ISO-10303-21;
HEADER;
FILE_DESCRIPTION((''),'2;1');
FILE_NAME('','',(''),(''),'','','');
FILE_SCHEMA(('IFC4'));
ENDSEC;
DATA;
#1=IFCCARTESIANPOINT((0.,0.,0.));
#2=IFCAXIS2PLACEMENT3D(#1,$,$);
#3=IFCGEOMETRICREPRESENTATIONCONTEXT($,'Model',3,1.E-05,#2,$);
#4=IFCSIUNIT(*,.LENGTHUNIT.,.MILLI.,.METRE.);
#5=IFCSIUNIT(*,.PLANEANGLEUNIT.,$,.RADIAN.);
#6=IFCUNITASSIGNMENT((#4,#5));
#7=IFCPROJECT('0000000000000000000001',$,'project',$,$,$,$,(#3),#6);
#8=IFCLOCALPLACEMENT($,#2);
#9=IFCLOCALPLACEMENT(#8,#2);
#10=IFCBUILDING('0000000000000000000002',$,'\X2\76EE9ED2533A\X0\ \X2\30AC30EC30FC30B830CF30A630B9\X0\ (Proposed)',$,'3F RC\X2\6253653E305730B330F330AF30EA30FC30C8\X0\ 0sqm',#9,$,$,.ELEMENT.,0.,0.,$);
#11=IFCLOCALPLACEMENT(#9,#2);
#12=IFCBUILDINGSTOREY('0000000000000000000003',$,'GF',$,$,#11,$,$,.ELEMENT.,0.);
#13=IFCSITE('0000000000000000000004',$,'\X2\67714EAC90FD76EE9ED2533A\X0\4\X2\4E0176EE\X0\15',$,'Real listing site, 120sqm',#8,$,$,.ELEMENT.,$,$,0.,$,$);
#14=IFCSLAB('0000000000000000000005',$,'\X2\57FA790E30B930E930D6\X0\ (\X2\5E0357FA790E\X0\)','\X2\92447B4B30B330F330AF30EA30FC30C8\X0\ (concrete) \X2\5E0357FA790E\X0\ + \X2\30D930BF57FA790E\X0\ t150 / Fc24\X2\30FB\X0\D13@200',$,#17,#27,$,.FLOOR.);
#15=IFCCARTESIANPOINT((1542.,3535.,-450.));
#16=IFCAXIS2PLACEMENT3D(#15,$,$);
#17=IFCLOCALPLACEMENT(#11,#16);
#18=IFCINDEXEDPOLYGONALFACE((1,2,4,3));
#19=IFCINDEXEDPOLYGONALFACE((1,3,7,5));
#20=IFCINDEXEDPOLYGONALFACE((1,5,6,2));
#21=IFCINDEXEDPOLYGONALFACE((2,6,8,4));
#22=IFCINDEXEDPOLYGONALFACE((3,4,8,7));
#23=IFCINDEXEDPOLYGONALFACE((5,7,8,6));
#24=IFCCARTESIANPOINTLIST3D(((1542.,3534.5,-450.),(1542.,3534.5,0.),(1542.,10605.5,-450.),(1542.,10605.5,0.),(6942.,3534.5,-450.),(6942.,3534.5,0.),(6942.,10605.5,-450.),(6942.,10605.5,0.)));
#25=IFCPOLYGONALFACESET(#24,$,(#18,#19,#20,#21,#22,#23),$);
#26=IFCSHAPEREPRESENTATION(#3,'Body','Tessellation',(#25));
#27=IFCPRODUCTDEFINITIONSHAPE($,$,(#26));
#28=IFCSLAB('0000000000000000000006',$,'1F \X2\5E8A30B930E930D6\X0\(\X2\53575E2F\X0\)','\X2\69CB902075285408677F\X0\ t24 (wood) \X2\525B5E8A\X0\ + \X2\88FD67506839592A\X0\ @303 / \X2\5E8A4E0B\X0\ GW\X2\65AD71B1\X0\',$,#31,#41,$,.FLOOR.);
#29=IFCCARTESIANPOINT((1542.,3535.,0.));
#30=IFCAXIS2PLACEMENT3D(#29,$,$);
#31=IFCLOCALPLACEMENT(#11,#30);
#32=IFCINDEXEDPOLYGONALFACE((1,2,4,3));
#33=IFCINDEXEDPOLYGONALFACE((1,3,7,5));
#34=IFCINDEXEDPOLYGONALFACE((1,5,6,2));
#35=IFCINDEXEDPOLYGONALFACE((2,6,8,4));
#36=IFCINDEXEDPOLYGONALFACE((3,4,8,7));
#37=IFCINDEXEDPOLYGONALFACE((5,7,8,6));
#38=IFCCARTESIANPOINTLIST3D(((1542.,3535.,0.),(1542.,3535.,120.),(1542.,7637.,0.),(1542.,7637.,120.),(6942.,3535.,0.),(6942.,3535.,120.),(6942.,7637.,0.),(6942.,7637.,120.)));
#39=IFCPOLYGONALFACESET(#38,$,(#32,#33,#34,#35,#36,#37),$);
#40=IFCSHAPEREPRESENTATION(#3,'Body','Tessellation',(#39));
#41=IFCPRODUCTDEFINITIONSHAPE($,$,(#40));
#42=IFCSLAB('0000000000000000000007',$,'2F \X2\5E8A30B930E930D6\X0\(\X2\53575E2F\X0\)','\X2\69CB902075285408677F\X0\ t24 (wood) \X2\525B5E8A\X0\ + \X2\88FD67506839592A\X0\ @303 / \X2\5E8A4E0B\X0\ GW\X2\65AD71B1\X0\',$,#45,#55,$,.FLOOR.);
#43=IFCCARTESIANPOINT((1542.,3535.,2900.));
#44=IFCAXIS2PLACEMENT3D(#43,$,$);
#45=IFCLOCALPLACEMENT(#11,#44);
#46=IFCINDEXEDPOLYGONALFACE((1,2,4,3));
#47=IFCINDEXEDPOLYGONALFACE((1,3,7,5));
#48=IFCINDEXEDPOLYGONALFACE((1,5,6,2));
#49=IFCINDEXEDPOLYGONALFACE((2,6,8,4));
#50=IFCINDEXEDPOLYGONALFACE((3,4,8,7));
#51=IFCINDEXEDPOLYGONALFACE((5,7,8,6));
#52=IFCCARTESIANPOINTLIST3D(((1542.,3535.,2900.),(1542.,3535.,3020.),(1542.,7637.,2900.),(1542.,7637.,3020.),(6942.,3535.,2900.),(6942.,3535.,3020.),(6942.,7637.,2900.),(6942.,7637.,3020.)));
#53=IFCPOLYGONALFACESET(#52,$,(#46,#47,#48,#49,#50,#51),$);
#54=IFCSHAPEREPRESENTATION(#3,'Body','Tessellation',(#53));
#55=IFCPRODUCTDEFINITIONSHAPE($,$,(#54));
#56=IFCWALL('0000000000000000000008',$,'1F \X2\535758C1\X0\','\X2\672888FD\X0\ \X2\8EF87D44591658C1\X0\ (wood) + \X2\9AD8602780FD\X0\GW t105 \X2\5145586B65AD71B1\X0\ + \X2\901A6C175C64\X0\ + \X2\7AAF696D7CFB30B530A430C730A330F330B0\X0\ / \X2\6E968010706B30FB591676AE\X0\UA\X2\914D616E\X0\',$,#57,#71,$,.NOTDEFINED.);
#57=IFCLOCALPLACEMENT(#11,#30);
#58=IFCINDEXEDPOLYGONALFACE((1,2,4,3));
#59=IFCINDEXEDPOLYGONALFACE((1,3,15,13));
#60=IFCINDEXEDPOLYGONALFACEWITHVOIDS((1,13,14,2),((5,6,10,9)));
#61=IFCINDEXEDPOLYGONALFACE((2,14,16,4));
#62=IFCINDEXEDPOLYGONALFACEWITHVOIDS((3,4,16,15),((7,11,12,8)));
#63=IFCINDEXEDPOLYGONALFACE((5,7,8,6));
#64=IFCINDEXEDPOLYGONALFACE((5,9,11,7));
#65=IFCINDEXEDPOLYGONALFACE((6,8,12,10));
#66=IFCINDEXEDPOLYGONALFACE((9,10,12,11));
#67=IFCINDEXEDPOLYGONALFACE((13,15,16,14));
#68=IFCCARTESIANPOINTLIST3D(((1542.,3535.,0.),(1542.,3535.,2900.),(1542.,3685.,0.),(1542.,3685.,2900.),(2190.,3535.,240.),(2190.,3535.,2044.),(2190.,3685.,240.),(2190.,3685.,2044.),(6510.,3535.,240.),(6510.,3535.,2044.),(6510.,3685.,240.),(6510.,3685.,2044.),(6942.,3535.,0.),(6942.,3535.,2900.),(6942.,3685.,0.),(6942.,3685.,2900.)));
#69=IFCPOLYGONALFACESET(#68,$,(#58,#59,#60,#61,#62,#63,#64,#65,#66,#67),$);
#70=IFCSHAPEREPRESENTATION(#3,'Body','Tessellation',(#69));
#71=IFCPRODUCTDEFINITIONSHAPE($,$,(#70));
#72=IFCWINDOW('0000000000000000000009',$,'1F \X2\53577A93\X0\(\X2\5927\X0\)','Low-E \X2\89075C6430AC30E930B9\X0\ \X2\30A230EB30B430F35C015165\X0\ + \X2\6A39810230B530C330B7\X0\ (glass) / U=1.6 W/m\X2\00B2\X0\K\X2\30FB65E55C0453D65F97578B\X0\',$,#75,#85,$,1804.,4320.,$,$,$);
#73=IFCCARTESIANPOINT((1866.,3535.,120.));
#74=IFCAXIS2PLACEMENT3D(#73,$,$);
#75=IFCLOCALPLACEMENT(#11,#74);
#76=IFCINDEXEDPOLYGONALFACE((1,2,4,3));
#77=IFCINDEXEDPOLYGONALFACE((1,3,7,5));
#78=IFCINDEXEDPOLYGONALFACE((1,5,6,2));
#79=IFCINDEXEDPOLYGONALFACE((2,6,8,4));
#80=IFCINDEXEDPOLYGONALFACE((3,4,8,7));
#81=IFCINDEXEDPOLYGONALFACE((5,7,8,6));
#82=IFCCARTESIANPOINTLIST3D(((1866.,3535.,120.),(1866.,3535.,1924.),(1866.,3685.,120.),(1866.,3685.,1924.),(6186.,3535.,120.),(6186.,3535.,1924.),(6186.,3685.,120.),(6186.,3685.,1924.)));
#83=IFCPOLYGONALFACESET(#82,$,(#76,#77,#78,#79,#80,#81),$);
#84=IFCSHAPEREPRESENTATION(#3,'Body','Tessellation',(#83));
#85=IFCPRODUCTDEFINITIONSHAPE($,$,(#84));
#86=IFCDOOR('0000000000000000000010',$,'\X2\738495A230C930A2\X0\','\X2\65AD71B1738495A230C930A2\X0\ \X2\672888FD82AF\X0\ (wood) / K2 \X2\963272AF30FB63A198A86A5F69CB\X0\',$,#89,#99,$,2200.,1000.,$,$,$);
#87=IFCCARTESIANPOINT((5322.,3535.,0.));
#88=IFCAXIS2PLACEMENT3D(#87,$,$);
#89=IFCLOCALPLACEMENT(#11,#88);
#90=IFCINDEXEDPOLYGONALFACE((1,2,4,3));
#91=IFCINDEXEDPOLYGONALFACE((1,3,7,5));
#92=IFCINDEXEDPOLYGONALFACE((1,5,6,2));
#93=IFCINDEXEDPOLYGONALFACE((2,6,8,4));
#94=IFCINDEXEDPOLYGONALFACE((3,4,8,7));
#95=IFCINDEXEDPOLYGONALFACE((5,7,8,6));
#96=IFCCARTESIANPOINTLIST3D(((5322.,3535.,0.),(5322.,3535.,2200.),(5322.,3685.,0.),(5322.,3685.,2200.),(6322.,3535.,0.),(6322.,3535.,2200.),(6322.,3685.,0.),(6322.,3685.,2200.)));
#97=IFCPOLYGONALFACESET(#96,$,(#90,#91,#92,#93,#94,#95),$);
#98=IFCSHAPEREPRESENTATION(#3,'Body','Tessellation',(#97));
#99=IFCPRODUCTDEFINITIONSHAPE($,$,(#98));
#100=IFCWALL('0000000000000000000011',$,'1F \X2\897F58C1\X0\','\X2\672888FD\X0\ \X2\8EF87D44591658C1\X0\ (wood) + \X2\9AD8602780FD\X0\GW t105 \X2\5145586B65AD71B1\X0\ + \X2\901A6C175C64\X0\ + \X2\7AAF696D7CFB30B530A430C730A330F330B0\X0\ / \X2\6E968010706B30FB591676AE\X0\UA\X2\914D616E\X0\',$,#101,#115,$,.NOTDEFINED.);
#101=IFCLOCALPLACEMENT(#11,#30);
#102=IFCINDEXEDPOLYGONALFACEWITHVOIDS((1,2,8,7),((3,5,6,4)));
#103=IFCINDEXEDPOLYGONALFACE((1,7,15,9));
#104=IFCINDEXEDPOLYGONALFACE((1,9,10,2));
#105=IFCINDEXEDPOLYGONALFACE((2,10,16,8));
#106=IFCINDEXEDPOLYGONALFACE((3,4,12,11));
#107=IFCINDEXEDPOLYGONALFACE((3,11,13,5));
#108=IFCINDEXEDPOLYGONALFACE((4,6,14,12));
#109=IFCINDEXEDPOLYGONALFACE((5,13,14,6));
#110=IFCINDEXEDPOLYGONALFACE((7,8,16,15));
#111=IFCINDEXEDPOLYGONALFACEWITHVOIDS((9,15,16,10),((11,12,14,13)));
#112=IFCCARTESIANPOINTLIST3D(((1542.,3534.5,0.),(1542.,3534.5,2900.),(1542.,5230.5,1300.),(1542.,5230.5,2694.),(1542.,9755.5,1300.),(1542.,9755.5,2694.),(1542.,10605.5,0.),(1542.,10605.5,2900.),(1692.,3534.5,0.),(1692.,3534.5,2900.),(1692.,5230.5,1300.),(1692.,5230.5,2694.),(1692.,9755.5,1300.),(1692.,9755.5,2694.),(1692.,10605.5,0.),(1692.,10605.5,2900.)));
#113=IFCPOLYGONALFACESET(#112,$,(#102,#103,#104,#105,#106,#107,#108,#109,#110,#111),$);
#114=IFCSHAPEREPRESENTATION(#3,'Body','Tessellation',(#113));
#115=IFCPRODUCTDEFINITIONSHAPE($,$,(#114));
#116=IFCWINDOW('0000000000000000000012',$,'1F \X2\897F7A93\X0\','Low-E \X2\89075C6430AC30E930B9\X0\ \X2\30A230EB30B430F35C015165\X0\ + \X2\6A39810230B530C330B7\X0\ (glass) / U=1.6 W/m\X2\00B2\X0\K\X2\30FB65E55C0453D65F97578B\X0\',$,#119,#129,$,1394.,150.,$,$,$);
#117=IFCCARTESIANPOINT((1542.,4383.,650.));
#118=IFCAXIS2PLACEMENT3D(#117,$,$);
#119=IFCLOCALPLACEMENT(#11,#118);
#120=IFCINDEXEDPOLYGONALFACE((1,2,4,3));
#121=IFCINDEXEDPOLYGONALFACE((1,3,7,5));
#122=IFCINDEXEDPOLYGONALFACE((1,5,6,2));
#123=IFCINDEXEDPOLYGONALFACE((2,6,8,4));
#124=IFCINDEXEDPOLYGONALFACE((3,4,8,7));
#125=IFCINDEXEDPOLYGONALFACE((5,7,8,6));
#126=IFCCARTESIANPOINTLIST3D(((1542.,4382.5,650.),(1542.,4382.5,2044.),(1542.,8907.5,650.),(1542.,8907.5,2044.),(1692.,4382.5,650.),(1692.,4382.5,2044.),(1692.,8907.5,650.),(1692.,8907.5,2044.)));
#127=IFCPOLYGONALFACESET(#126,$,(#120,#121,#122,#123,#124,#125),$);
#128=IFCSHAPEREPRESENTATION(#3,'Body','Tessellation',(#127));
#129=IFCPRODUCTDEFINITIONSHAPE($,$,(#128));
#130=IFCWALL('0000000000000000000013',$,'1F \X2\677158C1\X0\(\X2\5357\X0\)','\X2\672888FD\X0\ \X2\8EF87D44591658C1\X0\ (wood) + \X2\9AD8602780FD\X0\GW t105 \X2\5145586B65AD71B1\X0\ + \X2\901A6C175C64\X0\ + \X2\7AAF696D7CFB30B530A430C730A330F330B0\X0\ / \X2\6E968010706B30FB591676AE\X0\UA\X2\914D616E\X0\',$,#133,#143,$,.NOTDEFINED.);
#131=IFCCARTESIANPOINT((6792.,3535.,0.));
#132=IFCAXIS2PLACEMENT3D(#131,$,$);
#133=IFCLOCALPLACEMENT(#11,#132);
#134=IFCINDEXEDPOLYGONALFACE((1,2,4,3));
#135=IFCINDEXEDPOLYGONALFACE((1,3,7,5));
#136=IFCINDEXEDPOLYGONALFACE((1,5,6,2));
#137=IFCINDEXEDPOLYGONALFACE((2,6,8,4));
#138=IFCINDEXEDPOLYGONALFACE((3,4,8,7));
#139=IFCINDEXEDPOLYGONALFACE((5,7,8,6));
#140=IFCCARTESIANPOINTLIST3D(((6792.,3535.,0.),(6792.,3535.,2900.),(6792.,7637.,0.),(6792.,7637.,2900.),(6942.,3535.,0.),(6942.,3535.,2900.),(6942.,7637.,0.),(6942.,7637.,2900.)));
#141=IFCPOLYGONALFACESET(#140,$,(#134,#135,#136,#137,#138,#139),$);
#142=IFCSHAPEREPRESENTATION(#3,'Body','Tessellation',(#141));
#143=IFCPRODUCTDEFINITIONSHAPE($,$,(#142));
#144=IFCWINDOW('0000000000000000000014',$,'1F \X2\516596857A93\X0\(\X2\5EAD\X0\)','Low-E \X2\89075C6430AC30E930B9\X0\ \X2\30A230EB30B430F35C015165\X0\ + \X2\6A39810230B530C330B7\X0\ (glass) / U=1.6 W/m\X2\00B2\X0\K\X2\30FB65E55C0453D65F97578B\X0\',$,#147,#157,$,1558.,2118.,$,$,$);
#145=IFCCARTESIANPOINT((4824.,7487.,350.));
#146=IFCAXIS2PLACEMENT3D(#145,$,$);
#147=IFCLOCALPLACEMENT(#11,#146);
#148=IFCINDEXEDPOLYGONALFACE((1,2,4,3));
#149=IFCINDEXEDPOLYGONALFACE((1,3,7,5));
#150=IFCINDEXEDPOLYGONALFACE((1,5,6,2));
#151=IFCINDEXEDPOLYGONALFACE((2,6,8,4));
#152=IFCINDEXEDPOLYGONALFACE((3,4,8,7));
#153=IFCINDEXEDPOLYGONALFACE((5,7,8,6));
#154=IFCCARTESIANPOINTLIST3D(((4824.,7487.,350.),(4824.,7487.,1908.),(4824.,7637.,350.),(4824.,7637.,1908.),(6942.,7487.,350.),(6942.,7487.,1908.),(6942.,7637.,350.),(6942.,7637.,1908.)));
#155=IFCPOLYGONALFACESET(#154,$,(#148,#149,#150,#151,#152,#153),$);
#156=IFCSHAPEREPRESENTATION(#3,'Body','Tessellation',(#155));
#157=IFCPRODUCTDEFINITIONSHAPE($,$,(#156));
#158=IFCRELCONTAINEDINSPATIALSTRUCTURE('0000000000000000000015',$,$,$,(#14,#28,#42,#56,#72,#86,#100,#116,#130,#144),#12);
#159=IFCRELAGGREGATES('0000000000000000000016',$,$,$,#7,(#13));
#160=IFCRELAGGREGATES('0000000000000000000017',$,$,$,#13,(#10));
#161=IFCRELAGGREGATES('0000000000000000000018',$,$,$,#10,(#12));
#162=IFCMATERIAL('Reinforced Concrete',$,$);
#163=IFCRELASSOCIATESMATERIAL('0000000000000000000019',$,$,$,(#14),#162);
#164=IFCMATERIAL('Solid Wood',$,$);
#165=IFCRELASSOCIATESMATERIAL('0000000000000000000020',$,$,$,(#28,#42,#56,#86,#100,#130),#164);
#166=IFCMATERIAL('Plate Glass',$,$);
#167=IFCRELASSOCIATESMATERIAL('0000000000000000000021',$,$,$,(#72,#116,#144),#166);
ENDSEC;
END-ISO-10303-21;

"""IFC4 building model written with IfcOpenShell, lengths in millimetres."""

from ifc_helpers import new_model, si_unit, frame, frame_2d, origin, place, context, project, spatial, rectangle, extrude, material, element, fill, save


model = new_model("IFC4")

# Units and contexts
model_context = context("Model", 3, precision=1e-05, world=origin())
ifc_project = project(units=[si_unit("LENGTHUNIT", "METRE", prefix="MILLI"), si_unit("PLANEANGLEUNIT", "RADIAN")], contexts=[model_context])

# Site, building, storey
site_placement = place(None, origin())
site = spatial("IfcSite", under=ifc_project, at=site_placement, Name="東京都目黒区4丁目15", ObjectType="Real listing site, 120sqm", CompositionType="ELEMENT", RefElevation=0.0)
building_placement = place(site_placement, origin())
building = spatial("IfcBuilding", under=site, at=building_placement, Name="目黒区 ガレージハウス (Proposed)", ObjectType="3F RC打放しコンクリート 0sqm", CompositionType="ELEMENT", ElevationOfRefHeight=0.0, ElevationOfTerrain=0.0)
storey_placement = place(building_placement, origin())
storey = spatial("IfcBuildingStorey", under=building, at=storey_placement, Name="GF", CompositionType="ELEMENT", Elevation=0.0)

# Slabs
ifc_material_1 = material(Name="Reinforced Concrete")
slab_1_placement = place(storey_placement, frame((1542.0, 3535.0, -450.0)))
element("IfcSlab", 1, at=slab_1_placement, inside=storey, material=ifc_material_1, Name="基礎スラブ (布基礎)", Description="鉄筋コンクリート (concrete) 布基礎 + ベタ基礎 t150 / Fc24・D13@200", PredefinedType="FLOOR", context=model_context, shape_type="SweptSolid", body=[
    extrude(rectangle(XDim=5400.0, YDim=7071.0, at=frame_2d((2700.0, 3535.0))), frame((1542.0, 3535.0, -450.0)), (0.0, 0.0, 1.0), 450.0),
])
ifc_material_2 = material(Name="Solid Wood")
slab_2_placement = place(storey_placement, frame((1542.0, 3535.0, 0.0)))
element("IfcSlab", 2, at=slab_2_placement, inside=storey, material=ifc_material_2, Name="1F 床スラブ(南帯)", Description="構造用合板 t24 (wood) 剛床 + 製材根太 @303 / 床下 GW断熱", PredefinedType="FLOOR", context=model_context, shape_type="SweptSolid", body=[
    extrude(rectangle(XDim=5400.0, YDim=4102.0, at=frame_2d((2700.0, 2051.0))), frame((1542.0, 3535.0, 0.0)), (0.0, 0.0, 1.0), 120.0),
])
slab_3_placement = place(storey_placement, frame((1542.0, 3535.0, 2900.0)))
element("IfcSlab", 3, at=slab_3_placement, inside=storey, material=ifc_material_2, Name="2F 床スラブ(南帯)", Description="構造用合板 t24 (wood) 剛床 + 製材根太 @303 / 床下 GW断熱", PredefinedType="FLOOR", context=model_context, shape_type="SweptSolid", body=[
    extrude(rectangle(XDim=5400.0, YDim=4102.0, at=frame_2d((2700.0, 2051.0))), frame((1542.0, 3535.0, 2900.0)), (0.0, 0.0, 1.0), 120.0),
])

# Wall, openings, window, door
wall_1_placement = place(storey_placement, frame((1542.0, 3535.0, 0.0)))
wall_1 = element("IfcWall", 4, at=wall_1_placement, inside=storey, material=ifc_material_2, Name="1F 南壁", Description="木製 軸組外壁 (wood) + 高性能GW t105 充填断熱 + 通気層 + 窯業系サイディング / 準耐火・外皮UA配慮", PredefinedType="NOTDEFINED", context=model_context, shape_type="SweptSolid", body=[
    extrude(rectangle(XDim=5400.0, YDim=150.0, at=frame_2d((2700.0, 75.0))), frame((1542.0, 3535.0, 0.0)), (0.0, 0.0, 1.0), 2900.0),
])
opening_1_placement = place(storey_placement, frame((1866.0, 3535.0, 120.0)))
opening_1 = element("IfcOpeningElement", 5, at=opening_1_placement, cuts=wall_1, PredefinedType="NOTDEFINED", context=model_context, shape_type="SweptSolid", body=[
    extrude(rectangle(XDim=4320.0, YDim=150.0, at=frame_2d((2160.0, 75.0))), frame((1866.0, 3535.0, 120.0)), (0.0, 0.0, 1.0), 1804.0),
])
opening_2_placement = place(storey_placement, frame((5322.0, 3535.0, 0.0)))
opening_2 = element("IfcOpeningElement", 6, at=opening_2_placement, cuts=wall_1, PredefinedType="NOTDEFINED", context=model_context, shape_type="SweptSolid", body=[
    extrude(rectangle(XDim=1000.0, YDim=150.0, at=frame_2d((500.0, 75.0))), frame((5322.0, 3535.0, 0.0)), (0.0, 0.0, 1.0), 2200.0),
])
ifc_material_3 = material(Name="Plate Glass")
window_1_placement = place(storey_placement, frame((1866.0, 3535.0, 120.0)))
window_1 = element("IfcWindow", 7, at=window_1_placement, inside=storey, material=ifc_material_3, Name="1F 南窓(大)", Description="Low-E 複層ガラス アルゴン封入 + 樹脂サッシ (glass) / U=1.6 W/m²K・日射取得型", OverallHeight=1804.0, OverallWidth=4320.0, context=model_context, shape_type="SweptSolid", body=[
    extrude(rectangle(XDim=4320.0, YDim=150.0, at=frame_2d((2160.0, 75.0))), frame((1866.0, 3535.0, 120.0)), (0.0, 0.0, 1.0), 1804.0),
])
fill(opening_1, window_1)
door_1_placement = place(storey_placement, frame((5322.0, 3535.0, 0.0)))
door_1 = element("IfcDoor", 8, at=door_1_placement, inside=storey, material=ifc_material_2, Name="玄関ドア", Description="断熱玄関ドア 木製芯 (wood) / K2 防犯・採風機構", OverallHeight=2200.0, OverallWidth=1000.0, context=model_context, shape_type="SweptSolid", body=[
    extrude(rectangle(XDim=1000.0, YDim=150.0, at=frame_2d((500.0, 75.0))), frame((5322.0, 3535.0, 0.0)), (0.0, 0.0, 1.0), 2200.0),
])
fill(opening_2, door_1)

# Walls, openings, windows
wall_2_placement = place(storey_placement, frame((1542.0, 3535.0, 0.0)))
wall_2 = element("IfcWall", 9, at=wall_2_placement, inside=storey, material=ifc_material_2, Name="1F 西壁", Description="木製 軸組外壁 (wood) + 高性能GW t105 充填断熱 + 通気層 + 窯業系サイディング / 準耐火・外皮UA配慮", PredefinedType="NOTDEFINED", context=model_context, shape_type="SweptSolid", body=[
    extrude(rectangle(XDim=150.0, YDim=7071.0, at=frame_2d((75.0, 3535.0))), frame((1542.0, 3535.0, 0.0)), (0.0, 0.0, 1.0), 2900.0),
])
opening_3_placement = place(storey_placement, frame((1542.0, 4383.0, 650.0)))
opening_3 = element("IfcOpeningElement", 10, at=opening_3_placement, cuts=wall_2, PredefinedType="NOTDEFINED", context=model_context, shape_type="SweptSolid", body=[
    extrude(rectangle(XDim=150.0, YDim=4525.0, at=frame_2d((75.0, 2262.0))), frame((1542.0, 4383.0, 650.0)), (0.0, 0.0, 1.0), 1394.0),
])
window_2_placement = place(storey_placement, frame((1542.0, 4383.0, 650.0)))
window_2 = element("IfcWindow", 11, at=window_2_placement, inside=storey, material=ifc_material_3, Name="1F 西窓", Description="Low-E 複層ガラス アルゴン封入 + 樹脂サッシ (glass) / U=1.6 W/m²K・日射取得型", OverallHeight=1394.0, OverallWidth=150.0, context=model_context, shape_type="SweptSolid", body=[
    extrude(rectangle(XDim=150.0, YDim=4525.0, at=frame_2d((75.0, 2262.0))), frame((1542.0, 4383.0, 650.0)), (0.0, 0.0, 1.0), 1394.0),
])
fill(opening_3, window_2)
wall_3_placement = place(storey_placement, frame((6792.0, 3535.0, 0.0)))
wall_3 = element("IfcWall", 12, at=wall_3_placement, inside=storey, material=ifc_material_2, Name="1F 東壁(南)", Description="木製 軸組外壁 (wood) + 高性能GW t105 充填断熱 + 通気層 + 窯業系サイディング / 準耐火・外皮UA配慮", PredefinedType="NOTDEFINED", context=model_context, shape_type="SweptSolid", body=[
    extrude(rectangle(XDim=150.0, YDim=4102.0, at=frame_2d((75.0, 2051.0))), frame((6792.0, 3535.0, 0.0)), (0.0, 0.0, 1.0), 2900.0),
])
opening_4_placement = place(storey_placement, frame((4824.0, 7487.0, 350.0)))
opening_4 = element("IfcOpeningElement", 13, at=opening_4_placement, cuts=wall_3, PredefinedType="NOTDEFINED", context=model_context, shape_type="SweptSolid", body=[
    extrude(rectangle(XDim=2118.0, YDim=150.0, at=frame_2d((1059.0, 75.0))), frame((4824.0, 7487.0, 350.0)), (0.0, 0.0, 1.0), 1558.0),
])
window_3_placement = place(storey_placement, frame((4824.0, 7487.0, 350.0)))
window_3 = element("IfcWindow", 14, at=window_3_placement, inside=storey, material=ifc_material_3, Name="1F 入隅窓(庭)", Description="Low-E 複層ガラス アルゴン封入 + 樹脂サッシ (glass) / U=1.6 W/m²K・日射取得型", OverallHeight=1558.0, OverallWidth=2118.0, context=model_context, shape_type="SweptSolid", body=[
    extrude(rectangle(XDim=2118.0, YDim=150.0, at=frame_2d((1059.0, 75.0))), frame((4824.0, 7487.0, 350.0)), (0.0, 0.0, 1.0), 1558.0),
])
fill(opening_4, window_3)

save(model, "model.ifc")
